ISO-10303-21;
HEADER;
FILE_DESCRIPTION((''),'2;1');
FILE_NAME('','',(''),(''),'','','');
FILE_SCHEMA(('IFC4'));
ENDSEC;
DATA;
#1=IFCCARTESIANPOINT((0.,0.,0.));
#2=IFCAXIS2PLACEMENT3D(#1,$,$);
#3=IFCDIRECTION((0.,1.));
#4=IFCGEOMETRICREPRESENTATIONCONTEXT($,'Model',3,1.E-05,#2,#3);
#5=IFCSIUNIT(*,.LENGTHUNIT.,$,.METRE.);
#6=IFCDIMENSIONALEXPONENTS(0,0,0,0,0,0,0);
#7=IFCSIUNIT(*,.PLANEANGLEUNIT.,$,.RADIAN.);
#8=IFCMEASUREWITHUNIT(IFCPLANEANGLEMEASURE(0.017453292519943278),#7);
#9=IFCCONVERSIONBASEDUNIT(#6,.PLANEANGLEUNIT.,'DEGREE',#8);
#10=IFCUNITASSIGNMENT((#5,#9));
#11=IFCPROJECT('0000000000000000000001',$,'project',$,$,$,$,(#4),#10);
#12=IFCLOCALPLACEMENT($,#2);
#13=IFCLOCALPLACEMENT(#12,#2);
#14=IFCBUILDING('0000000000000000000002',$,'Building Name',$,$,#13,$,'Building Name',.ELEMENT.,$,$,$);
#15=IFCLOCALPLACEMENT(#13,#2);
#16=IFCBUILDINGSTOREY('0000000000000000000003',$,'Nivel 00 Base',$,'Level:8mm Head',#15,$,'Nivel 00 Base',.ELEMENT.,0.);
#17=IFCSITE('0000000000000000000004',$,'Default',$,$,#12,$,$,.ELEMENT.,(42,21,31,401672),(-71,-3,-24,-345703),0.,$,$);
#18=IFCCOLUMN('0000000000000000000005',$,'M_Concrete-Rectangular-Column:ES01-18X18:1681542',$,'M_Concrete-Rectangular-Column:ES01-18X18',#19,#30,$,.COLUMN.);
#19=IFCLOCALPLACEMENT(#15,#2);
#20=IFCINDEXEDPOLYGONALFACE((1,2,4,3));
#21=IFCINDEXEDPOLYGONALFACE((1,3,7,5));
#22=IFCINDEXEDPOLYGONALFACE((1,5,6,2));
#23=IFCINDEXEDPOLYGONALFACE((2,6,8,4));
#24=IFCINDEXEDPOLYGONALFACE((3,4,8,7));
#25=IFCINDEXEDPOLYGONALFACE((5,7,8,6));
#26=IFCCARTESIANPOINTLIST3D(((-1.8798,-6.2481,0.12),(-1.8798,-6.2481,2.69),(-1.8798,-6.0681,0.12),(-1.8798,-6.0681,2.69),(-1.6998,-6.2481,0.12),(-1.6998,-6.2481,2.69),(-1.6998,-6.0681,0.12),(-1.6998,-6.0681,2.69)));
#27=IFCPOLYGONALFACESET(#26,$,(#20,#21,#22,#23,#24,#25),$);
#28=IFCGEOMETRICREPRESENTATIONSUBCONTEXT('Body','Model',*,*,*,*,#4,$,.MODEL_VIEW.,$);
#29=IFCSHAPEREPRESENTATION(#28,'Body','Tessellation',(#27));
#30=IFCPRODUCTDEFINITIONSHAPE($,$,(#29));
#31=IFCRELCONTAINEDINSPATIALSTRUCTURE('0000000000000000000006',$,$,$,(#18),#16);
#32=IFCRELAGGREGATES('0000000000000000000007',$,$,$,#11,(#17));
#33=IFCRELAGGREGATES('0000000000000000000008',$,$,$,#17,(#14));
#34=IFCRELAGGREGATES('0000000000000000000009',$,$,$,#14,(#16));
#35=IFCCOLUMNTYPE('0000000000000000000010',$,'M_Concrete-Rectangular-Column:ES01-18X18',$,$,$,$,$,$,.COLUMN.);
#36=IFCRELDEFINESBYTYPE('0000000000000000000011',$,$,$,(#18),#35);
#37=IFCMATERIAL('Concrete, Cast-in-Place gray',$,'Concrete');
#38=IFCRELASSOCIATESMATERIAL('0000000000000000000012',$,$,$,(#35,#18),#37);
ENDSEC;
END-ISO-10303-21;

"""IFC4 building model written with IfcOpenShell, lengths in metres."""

from ifc_helpers import new_model, entity, si_unit, converted_unit, direction, frame, origin, place, context, subcontext, project, spatial, indexed_curve, outline, extrude, source, transform, mapped, material, type_object, type_shapes, element, save


model = new_model("IFC4")

# Units and contexts
model_context = context("Model", 3, precision=1e-05, world=origin(), true_north=direction((0.0, 1.0)))
body_context = subcontext(model_context, "Body", "Model", "MODEL_VIEW")
ifc_project = project(units=[si_unit("LENGTHUNIT", "METRE"), converted_unit("PLANEANGLEUNIT", "DEGREE", entity("IfcPlaneAngleMeasure", 0.017453292519943278), si_unit("PLANEANGLEUNIT", "RADIAN"), dimensions=[0, 0, 0, 0, 0, 0, 0])], contexts=[model_context])

# Site, building, storey
site_placement = place(None, origin())
site = spatial("IfcSite", under=ifc_project, at=site_placement, Name="Default", CompositionType="ELEMENT", RefLatitude=(42, 21, 31, 401672), RefLongitude=(-71, -3, -24, -345703), RefElevation=0.0)
building_placement = place(site_placement, origin())
building = spatial("IfcBuilding", under=site, at=building_placement, Name="Building Name", LongName="Building Name", CompositionType="ELEMENT")
storey_placement = place(building_placement, origin())
storey = spatial("IfcBuildingStorey", under=building, at=storey_placement, Name="Nivel 00 Base", ObjectType="Level:8mm Head", LongName="Nivel 00 Base", CompositionType="ELEMENT", Elevation=0.0)

# Column
ifc_material_1 = material(Name="Concrete, Cast-in-Place gray", Category="Concrete")
column_type_1 = type_object("IfcColumnType", Name="M_Concrete-Rectangular-Column:ES01-18X18", PredefinedType="COLUMN", material=ifc_material_1)
shared_shape_1 = source(origin(), body_context, "Body", "SweptSolid", [
    extrude(outline(indexed_curve([(-0.09, -0.09), (0.09, -0.09), (0.09, 0.09), (-0.09, 0.09), (-0.09, -0.09)], self_intersect=False)), frame((-1.7898, -6.1581, 0.12), z_axis=(0.0, 0.0, 1.0), x_axis=(-1.0, 0.0, 0.0)), (0.0, 0.0, 1.0), 2.57),
])
type_shapes(column_type_1, [shared_shape_1])
column_1_placement = place(storey_placement, origin())
element("IfcColumn", 1, at=column_1_placement, inside=storey, type_object=column_type_1, material=ifc_material_1, Name="M_Concrete-Rectangular-Column:ES01-18X18:1681542", ObjectType="M_Concrete-Rectangular-Column:ES01-18X18", PredefinedType="COLUMN", context=body_context, shape_type="MappedRepresentation", body=[
    mapped(shared_shape_1, transform((0.0, 0.0, 0.0), scale=1.0)),
])

save(model, "model.ifc")
